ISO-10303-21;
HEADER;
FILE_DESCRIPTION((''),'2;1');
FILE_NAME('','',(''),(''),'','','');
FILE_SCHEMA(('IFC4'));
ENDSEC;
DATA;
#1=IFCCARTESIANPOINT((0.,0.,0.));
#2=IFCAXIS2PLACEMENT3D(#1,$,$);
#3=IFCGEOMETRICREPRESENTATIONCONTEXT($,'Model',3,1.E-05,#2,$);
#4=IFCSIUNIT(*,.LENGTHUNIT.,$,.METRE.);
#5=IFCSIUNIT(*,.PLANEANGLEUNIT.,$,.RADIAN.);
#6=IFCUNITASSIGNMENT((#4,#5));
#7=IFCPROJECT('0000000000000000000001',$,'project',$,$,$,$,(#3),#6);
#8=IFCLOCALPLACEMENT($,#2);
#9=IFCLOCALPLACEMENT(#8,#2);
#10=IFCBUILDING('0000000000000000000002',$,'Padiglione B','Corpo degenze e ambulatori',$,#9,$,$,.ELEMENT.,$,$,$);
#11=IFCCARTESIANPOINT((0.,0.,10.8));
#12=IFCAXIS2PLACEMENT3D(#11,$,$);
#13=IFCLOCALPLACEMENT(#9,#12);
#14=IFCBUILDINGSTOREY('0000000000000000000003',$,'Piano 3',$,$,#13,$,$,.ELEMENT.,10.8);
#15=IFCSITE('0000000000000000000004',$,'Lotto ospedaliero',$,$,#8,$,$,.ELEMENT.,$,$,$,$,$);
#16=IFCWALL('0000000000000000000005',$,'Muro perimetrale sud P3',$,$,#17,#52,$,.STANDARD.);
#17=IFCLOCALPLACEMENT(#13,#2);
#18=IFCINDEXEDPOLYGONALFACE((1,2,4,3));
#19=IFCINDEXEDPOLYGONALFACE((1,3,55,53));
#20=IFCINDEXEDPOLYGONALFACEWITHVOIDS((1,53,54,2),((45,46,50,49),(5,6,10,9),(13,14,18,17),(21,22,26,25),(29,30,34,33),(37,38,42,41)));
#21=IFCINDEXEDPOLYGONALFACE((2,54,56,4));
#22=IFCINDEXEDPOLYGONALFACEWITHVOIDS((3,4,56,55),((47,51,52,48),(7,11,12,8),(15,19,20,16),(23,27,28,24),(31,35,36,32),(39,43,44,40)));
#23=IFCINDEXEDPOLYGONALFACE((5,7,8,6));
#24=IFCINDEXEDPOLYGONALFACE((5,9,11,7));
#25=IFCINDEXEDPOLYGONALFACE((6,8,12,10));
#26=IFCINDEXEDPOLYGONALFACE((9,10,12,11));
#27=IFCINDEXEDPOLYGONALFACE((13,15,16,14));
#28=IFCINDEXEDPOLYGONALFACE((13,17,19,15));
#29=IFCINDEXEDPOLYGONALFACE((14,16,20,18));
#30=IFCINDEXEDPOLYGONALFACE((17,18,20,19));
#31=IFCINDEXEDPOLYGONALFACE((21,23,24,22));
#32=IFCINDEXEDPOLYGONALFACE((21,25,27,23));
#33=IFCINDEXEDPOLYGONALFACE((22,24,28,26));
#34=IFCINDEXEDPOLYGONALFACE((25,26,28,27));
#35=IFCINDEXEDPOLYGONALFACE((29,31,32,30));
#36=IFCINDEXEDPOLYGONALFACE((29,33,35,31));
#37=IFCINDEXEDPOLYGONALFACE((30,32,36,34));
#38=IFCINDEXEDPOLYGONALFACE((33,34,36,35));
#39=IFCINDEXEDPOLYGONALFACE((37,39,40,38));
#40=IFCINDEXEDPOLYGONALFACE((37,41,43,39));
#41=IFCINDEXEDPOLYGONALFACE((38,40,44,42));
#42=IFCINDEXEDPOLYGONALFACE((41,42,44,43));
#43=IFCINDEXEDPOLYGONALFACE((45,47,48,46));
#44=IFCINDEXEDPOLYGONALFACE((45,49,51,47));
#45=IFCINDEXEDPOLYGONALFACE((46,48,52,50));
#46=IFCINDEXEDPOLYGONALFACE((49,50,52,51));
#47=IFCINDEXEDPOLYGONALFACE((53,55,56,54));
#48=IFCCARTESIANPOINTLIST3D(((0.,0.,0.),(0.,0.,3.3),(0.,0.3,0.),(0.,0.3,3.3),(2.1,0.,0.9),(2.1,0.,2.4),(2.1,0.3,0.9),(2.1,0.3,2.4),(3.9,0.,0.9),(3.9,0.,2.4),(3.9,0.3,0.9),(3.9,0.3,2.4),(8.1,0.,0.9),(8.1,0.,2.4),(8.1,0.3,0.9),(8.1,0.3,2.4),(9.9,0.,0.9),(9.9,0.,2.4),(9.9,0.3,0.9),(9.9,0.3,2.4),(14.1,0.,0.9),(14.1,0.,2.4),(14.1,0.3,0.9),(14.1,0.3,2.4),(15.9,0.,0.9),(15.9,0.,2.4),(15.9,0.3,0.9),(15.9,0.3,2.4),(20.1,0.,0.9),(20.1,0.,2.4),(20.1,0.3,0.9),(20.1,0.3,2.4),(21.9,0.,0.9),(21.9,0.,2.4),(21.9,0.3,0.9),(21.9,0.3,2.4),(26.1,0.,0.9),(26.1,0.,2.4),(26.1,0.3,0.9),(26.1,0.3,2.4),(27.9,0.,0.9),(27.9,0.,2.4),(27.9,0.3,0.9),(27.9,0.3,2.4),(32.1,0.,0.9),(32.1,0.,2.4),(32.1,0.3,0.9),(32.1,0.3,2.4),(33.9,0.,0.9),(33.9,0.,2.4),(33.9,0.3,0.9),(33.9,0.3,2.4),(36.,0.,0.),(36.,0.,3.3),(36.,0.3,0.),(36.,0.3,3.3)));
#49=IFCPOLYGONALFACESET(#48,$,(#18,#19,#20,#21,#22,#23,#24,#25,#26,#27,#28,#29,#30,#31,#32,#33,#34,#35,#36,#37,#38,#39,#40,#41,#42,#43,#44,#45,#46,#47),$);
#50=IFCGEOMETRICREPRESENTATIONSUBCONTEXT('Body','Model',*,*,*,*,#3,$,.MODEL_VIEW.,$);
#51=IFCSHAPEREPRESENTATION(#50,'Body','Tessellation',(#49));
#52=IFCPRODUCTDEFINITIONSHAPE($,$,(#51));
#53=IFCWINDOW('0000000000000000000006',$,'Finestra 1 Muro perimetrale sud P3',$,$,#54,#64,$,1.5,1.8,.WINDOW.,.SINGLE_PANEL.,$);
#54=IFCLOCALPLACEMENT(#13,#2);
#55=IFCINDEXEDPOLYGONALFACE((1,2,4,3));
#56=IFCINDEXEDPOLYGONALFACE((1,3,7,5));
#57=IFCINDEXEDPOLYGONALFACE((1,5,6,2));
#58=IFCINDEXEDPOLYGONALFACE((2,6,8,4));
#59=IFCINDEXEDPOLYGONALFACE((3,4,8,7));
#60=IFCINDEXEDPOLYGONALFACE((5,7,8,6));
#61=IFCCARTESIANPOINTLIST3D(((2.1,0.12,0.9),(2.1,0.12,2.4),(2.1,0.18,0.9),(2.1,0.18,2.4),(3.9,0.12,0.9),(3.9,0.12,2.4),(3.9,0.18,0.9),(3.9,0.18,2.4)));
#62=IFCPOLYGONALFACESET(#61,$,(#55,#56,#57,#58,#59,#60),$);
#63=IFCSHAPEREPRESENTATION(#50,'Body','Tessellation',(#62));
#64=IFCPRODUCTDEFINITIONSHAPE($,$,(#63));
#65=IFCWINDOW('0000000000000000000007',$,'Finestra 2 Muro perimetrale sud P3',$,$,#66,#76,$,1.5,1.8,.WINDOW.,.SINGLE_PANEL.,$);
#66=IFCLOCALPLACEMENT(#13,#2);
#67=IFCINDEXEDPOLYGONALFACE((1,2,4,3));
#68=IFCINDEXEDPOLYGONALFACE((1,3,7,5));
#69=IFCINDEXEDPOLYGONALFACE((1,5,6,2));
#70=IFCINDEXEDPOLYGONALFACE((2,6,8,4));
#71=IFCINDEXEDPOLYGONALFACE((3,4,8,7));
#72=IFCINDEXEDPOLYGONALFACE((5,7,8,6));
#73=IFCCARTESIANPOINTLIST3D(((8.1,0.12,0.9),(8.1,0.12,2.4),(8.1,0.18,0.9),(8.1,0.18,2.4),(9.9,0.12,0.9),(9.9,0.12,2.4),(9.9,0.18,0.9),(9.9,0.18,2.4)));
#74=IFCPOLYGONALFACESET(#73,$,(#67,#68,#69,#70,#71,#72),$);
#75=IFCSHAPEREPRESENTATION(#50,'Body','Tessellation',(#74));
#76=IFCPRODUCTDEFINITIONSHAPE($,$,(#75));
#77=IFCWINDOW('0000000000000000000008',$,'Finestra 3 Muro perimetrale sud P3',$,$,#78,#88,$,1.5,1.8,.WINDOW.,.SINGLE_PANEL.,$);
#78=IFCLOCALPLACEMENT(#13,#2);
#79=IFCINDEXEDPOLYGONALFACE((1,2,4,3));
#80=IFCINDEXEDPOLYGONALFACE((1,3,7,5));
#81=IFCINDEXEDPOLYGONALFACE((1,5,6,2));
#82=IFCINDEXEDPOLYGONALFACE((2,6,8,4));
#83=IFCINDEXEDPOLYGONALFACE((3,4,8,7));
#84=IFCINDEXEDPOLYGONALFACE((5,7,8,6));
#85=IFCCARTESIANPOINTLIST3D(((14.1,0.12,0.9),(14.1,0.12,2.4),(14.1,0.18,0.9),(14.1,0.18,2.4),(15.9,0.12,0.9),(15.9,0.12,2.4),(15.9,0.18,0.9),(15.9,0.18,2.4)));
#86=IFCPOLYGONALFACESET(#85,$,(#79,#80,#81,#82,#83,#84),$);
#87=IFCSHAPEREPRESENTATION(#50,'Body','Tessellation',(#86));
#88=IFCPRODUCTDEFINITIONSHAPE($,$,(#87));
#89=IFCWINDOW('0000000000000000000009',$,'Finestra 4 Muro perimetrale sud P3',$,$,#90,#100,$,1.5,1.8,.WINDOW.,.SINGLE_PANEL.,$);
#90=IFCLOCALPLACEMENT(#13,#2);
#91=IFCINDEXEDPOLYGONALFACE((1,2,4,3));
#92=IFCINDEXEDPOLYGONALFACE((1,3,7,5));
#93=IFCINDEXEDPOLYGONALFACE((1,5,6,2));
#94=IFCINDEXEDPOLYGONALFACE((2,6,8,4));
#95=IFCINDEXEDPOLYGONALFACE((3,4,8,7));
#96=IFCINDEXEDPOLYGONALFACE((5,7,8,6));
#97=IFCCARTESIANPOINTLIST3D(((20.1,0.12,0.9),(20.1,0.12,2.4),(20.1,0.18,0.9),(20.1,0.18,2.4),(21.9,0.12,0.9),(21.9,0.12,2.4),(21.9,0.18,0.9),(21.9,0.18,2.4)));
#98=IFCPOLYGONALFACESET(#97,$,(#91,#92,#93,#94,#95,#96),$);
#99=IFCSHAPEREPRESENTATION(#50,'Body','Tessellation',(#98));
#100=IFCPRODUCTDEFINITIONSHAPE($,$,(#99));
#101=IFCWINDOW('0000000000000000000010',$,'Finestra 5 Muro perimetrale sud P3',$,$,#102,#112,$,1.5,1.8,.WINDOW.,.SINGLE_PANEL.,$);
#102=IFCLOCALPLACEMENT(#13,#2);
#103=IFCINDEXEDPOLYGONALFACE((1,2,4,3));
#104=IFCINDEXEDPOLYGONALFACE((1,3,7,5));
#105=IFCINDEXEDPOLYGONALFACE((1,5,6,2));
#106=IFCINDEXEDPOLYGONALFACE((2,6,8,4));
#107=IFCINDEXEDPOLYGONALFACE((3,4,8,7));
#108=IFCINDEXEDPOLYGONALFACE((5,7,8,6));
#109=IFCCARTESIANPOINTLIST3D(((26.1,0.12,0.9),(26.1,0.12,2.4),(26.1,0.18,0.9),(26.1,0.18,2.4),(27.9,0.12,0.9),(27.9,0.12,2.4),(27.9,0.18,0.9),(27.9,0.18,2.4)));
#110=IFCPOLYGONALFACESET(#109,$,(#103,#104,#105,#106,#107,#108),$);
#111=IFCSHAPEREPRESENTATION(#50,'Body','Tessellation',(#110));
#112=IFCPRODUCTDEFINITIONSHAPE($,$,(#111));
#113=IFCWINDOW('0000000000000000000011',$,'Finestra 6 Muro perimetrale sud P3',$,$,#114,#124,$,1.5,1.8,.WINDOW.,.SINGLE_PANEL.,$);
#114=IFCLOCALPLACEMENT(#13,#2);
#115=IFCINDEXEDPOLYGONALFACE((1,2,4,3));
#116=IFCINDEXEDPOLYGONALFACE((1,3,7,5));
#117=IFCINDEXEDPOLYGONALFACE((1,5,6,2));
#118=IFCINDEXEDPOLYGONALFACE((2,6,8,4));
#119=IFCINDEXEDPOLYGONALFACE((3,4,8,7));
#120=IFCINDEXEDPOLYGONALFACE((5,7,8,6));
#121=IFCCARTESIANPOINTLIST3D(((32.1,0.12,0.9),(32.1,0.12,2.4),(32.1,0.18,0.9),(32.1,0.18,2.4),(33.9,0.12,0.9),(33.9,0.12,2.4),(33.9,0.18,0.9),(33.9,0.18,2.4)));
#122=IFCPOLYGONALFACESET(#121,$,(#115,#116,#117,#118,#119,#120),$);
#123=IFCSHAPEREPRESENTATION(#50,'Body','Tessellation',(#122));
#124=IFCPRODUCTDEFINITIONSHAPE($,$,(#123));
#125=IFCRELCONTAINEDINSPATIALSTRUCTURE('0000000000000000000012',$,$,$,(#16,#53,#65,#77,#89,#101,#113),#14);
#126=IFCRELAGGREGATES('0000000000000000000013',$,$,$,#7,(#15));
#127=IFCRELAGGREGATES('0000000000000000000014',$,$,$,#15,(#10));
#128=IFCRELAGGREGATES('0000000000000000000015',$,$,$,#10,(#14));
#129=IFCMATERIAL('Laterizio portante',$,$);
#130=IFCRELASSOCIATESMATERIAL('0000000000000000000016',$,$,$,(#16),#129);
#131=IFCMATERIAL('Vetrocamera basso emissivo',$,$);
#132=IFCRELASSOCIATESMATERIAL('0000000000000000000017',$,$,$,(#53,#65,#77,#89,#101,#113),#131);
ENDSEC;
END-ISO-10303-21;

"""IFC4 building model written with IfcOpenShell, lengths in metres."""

from ifc_helpers import new_model, si_unit, frame, frame_2d, origin, place, context, subcontext, project, spatial, rectangle, extrude, material, element, fill, save


model = new_model("IFC4")

# Units and contexts
model_context = context("Model", 3, precision=1e-05, world=origin())
body_context = subcontext(model_context, "Body", "Model", "MODEL_VIEW")
ifc_project = project(units=[si_unit("LENGTHUNIT", "METRE"), si_unit("PLANEANGLEUNIT", "RADIAN")], contexts=[model_context])

# Site, building, storey
site_placement = place(None, origin())
site = spatial("IfcSite", under=ifc_project, at=site_placement, Name="Lotto ospedaliero", CompositionType="ELEMENT")
building_placement = place(site_placement, origin())
building = spatial("IfcBuilding", under=site, at=building_placement, Name="Padiglione B", Description="Corpo degenze e ambulatori", CompositionType="ELEMENT")
storey_placement = place(building_placement, frame((0.0, 0.0, 10.8)))
storey = spatial("IfcBuildingStorey", under=building, at=storey_placement, Name="Piano 3", CompositionType="ELEMENT", Elevation=10.8)

# Wall, openings, windows
ifc_material_1 = material(Name="Laterizio portante")
wall_1_placement = place(storey_placement, origin())
wall_1 = element("IfcWall", 1, at=wall_1_placement, inside=storey, material=ifc_material_1, Name="Muro perimetrale sud P3", PredefinedType="STANDARD", context=body_context, shape_type="SweptSolid", body=[
    extrude(rectangle(XDim=36.0, YDim=0.3, at=frame_2d((18.0, 0.15))), origin(), (0.0, 0.0, 1.0), 3.3),
])
opening_1_placement = place(wall_1_placement, frame((2.1, -0.1, 0.9)))
opening_1 = element("IfcOpeningElement", 2, at=opening_1_placement, cuts=wall_1, PredefinedType="OPENING", context=body_context, shape_type="SweptSolid", body=[
    extrude(rectangle(XDim=1.8, YDim=0.5, at=frame_2d((0.9, 0.25))), origin(), (0.0, 0.0, 1.0), 1.5),
])
opening_2_placement = place(wall_1_placement, frame((8.1, -0.1, 0.9)))
opening_2 = element("IfcOpeningElement", 3, at=opening_2_placement, cuts=wall_1, PredefinedType="OPENING", context=body_context, shape_type="SweptSolid", body=[
    extrude(rectangle(XDim=1.8, YDim=0.5, at=frame_2d((0.9, 0.25))), origin(), (0.0, 0.0, 1.0), 1.5),
])
opening_3_placement = place(wall_1_placement, frame((14.1, -0.1, 0.9)))
opening_3 = element("IfcOpeningElement", 4, at=opening_3_placement, cuts=wall_1, PredefinedType="OPENING", context=body_context, shape_type="SweptSolid", body=[
    extrude(rectangle(XDim=1.8, YDim=0.5, at=frame_2d((0.9, 0.25))), origin(), (0.0, 0.0, 1.0), 1.5),
])
opening_4_placement = place(wall_1_placement, frame((20.1, -0.1, 0.9)))
opening_4 = element("IfcOpeningElement", 5, at=opening_4_placement, cuts=wall_1, PredefinedType="OPENING", context=body_context, shape_type="SweptSolid", body=[
    extrude(rectangle(XDim=1.8, YDim=0.5, at=frame_2d((0.9, 0.25))), origin(), (0.0, 0.0, 1.0), 1.5),
])
opening_5_placement = place(wall_1_placement, frame((26.1, -0.1, 0.9)))
opening_5 = element("IfcOpeningElement", 6, at=opening_5_placement, cuts=wall_1, PredefinedType="OPENING", context=body_context, shape_type="SweptSolid", body=[
    extrude(rectangle(XDim=1.8, YDim=0.5, at=frame_2d((0.9, 0.25))), origin(), (0.0, 0.0, 1.0), 1.5),
])
opening_6_placement = place(wall_1_placement, frame((32.1, -0.1, 0.9)))
opening_6 = element("IfcOpeningElement", 7, at=opening_6_placement, cuts=wall_1, PredefinedType="OPENING", context=body_context, shape_type="SweptSolid", body=[
    extrude(rectangle(XDim=1.8, YDim=0.5, at=frame_2d((0.9, 0.25))), origin(), (0.0, 0.0, 1.0), 1.5),
])
ifc_material_2 = material(Name="Vetrocamera basso emissivo")
window_1_placement = place(wall_1_placement, frame((2.1, 0.12, 0.9)))
window_1 = element("IfcWindow", 8, at=window_1_placement, inside=storey, material=ifc_material_2, Name="Finestra 1 Muro perimetrale sud P3", OverallHeight=1.5, OverallWidth=1.8, PartitioningType="SINGLE_PANEL", PredefinedType="WINDOW", context=body_context, shape_type="SweptSolid", body=[
    extrude(rectangle(XDim=1.8, YDim=0.06, at=frame_2d((0.9, 0.03))), origin(), (0.0, 0.0, 1.0), 1.5),
])
fill(opening_1, window_1)
window_2_placement = place(wall_1_placement, frame((8.1, 0.12, 0.9)))
window_2 = element("IfcWindow", 9, at=window_2_placement, inside=storey, material=ifc_material_2, Name="Finestra 2 Muro perimetrale sud P3", OverallHeight=1.5, OverallWidth=1.8, PartitioningType="SINGLE_PANEL", PredefinedType="WINDOW", context=body_context, shape_type="SweptSolid", body=[
    extrude(rectangle(XDim=1.8, YDim=0.06, at=frame_2d((0.9, 0.03))), origin(), (0.0, 0.0, 1.0), 1.5),
])
fill(opening_2, window_2)
window_3_placement = place(wall_1_placement, frame((14.1, 0.12, 0.9)))
window_3 = element("IfcWindow", 10, at=window_3_placement, inside=storey, material=ifc_material_2, Name="Finestra 3 Muro perimetrale sud P3", OverallHeight=1.5, OverallWidth=1.8, PartitioningType="SINGLE_PANEL", PredefinedType="WINDOW", context=body_context, shape_type="SweptSolid", body=[
    extrude(rectangle(XDim=1.8, YDim=0.06, at=frame_2d((0.9, 0.03))), origin(), (0.0, 0.0, 1.0), 1.5),
])
fill(opening_3, window_3)
window_4_placement = place(wall_1_placement, frame((20.1, 0.12, 0.9)))
window_4 = element("IfcWindow", 11, at=window_4_placement, inside=storey, material=ifc_material_2, Name="Finestra 4 Muro perimetrale sud P3", OverallHeight=1.5, OverallWidth=1.8, PartitioningType="SINGLE_PANEL", PredefinedType="WINDOW", context=body_context, shape_type="SweptSolid", body=[
    extrude(rectangle(XDim=1.8, YDim=0.06, at=frame_2d((0.9, 0.03))), origin(), (0.0, 0.0, 1.0), 1.5),
])
fill(opening_4, window_4)
window_5_placement = place(wall_1_placement, frame((26.1, 0.12, 0.9)))
window_5 = element("IfcWindow", 12, at=window_5_placement, inside=storey, material=ifc_material_2, Name="Finestra 5 Muro perimetrale sud P3", OverallHeight=1.5, OverallWidth=1.8, PartitioningType="SINGLE_PANEL", PredefinedType="WINDOW", context=body_context, shape_type="SweptSolid", body=[
    extrude(rectangle(XDim=1.8, YDim=0.06, at=frame_2d((0.9, 0.03))), origin(), (0.0, 0.0, 1.0), 1.5),
])
fill(opening_5, window_5)
window_6_placement = place(wall_1_placement, frame((32.1, 0.12, 0.9)))
window_6 = element("IfcWindow", 13, at=window_6_placement, inside=storey, material=ifc_material_2, Name="Finestra 6 Muro perimetrale sud P3", OverallHeight=1.5, OverallWidth=1.8, PartitioningType="SINGLE_PANEL", PredefinedType="WINDOW", context=body_context, shape_type="SweptSolid", body=[
    extrude(rectangle(XDim=1.8, YDim=0.06, at=frame_2d((0.9, 0.03))), origin(), (0.0, 0.0, 1.0), 1.5),
])
fill(opening_6, window_6)

save(model, "model.ifc")
